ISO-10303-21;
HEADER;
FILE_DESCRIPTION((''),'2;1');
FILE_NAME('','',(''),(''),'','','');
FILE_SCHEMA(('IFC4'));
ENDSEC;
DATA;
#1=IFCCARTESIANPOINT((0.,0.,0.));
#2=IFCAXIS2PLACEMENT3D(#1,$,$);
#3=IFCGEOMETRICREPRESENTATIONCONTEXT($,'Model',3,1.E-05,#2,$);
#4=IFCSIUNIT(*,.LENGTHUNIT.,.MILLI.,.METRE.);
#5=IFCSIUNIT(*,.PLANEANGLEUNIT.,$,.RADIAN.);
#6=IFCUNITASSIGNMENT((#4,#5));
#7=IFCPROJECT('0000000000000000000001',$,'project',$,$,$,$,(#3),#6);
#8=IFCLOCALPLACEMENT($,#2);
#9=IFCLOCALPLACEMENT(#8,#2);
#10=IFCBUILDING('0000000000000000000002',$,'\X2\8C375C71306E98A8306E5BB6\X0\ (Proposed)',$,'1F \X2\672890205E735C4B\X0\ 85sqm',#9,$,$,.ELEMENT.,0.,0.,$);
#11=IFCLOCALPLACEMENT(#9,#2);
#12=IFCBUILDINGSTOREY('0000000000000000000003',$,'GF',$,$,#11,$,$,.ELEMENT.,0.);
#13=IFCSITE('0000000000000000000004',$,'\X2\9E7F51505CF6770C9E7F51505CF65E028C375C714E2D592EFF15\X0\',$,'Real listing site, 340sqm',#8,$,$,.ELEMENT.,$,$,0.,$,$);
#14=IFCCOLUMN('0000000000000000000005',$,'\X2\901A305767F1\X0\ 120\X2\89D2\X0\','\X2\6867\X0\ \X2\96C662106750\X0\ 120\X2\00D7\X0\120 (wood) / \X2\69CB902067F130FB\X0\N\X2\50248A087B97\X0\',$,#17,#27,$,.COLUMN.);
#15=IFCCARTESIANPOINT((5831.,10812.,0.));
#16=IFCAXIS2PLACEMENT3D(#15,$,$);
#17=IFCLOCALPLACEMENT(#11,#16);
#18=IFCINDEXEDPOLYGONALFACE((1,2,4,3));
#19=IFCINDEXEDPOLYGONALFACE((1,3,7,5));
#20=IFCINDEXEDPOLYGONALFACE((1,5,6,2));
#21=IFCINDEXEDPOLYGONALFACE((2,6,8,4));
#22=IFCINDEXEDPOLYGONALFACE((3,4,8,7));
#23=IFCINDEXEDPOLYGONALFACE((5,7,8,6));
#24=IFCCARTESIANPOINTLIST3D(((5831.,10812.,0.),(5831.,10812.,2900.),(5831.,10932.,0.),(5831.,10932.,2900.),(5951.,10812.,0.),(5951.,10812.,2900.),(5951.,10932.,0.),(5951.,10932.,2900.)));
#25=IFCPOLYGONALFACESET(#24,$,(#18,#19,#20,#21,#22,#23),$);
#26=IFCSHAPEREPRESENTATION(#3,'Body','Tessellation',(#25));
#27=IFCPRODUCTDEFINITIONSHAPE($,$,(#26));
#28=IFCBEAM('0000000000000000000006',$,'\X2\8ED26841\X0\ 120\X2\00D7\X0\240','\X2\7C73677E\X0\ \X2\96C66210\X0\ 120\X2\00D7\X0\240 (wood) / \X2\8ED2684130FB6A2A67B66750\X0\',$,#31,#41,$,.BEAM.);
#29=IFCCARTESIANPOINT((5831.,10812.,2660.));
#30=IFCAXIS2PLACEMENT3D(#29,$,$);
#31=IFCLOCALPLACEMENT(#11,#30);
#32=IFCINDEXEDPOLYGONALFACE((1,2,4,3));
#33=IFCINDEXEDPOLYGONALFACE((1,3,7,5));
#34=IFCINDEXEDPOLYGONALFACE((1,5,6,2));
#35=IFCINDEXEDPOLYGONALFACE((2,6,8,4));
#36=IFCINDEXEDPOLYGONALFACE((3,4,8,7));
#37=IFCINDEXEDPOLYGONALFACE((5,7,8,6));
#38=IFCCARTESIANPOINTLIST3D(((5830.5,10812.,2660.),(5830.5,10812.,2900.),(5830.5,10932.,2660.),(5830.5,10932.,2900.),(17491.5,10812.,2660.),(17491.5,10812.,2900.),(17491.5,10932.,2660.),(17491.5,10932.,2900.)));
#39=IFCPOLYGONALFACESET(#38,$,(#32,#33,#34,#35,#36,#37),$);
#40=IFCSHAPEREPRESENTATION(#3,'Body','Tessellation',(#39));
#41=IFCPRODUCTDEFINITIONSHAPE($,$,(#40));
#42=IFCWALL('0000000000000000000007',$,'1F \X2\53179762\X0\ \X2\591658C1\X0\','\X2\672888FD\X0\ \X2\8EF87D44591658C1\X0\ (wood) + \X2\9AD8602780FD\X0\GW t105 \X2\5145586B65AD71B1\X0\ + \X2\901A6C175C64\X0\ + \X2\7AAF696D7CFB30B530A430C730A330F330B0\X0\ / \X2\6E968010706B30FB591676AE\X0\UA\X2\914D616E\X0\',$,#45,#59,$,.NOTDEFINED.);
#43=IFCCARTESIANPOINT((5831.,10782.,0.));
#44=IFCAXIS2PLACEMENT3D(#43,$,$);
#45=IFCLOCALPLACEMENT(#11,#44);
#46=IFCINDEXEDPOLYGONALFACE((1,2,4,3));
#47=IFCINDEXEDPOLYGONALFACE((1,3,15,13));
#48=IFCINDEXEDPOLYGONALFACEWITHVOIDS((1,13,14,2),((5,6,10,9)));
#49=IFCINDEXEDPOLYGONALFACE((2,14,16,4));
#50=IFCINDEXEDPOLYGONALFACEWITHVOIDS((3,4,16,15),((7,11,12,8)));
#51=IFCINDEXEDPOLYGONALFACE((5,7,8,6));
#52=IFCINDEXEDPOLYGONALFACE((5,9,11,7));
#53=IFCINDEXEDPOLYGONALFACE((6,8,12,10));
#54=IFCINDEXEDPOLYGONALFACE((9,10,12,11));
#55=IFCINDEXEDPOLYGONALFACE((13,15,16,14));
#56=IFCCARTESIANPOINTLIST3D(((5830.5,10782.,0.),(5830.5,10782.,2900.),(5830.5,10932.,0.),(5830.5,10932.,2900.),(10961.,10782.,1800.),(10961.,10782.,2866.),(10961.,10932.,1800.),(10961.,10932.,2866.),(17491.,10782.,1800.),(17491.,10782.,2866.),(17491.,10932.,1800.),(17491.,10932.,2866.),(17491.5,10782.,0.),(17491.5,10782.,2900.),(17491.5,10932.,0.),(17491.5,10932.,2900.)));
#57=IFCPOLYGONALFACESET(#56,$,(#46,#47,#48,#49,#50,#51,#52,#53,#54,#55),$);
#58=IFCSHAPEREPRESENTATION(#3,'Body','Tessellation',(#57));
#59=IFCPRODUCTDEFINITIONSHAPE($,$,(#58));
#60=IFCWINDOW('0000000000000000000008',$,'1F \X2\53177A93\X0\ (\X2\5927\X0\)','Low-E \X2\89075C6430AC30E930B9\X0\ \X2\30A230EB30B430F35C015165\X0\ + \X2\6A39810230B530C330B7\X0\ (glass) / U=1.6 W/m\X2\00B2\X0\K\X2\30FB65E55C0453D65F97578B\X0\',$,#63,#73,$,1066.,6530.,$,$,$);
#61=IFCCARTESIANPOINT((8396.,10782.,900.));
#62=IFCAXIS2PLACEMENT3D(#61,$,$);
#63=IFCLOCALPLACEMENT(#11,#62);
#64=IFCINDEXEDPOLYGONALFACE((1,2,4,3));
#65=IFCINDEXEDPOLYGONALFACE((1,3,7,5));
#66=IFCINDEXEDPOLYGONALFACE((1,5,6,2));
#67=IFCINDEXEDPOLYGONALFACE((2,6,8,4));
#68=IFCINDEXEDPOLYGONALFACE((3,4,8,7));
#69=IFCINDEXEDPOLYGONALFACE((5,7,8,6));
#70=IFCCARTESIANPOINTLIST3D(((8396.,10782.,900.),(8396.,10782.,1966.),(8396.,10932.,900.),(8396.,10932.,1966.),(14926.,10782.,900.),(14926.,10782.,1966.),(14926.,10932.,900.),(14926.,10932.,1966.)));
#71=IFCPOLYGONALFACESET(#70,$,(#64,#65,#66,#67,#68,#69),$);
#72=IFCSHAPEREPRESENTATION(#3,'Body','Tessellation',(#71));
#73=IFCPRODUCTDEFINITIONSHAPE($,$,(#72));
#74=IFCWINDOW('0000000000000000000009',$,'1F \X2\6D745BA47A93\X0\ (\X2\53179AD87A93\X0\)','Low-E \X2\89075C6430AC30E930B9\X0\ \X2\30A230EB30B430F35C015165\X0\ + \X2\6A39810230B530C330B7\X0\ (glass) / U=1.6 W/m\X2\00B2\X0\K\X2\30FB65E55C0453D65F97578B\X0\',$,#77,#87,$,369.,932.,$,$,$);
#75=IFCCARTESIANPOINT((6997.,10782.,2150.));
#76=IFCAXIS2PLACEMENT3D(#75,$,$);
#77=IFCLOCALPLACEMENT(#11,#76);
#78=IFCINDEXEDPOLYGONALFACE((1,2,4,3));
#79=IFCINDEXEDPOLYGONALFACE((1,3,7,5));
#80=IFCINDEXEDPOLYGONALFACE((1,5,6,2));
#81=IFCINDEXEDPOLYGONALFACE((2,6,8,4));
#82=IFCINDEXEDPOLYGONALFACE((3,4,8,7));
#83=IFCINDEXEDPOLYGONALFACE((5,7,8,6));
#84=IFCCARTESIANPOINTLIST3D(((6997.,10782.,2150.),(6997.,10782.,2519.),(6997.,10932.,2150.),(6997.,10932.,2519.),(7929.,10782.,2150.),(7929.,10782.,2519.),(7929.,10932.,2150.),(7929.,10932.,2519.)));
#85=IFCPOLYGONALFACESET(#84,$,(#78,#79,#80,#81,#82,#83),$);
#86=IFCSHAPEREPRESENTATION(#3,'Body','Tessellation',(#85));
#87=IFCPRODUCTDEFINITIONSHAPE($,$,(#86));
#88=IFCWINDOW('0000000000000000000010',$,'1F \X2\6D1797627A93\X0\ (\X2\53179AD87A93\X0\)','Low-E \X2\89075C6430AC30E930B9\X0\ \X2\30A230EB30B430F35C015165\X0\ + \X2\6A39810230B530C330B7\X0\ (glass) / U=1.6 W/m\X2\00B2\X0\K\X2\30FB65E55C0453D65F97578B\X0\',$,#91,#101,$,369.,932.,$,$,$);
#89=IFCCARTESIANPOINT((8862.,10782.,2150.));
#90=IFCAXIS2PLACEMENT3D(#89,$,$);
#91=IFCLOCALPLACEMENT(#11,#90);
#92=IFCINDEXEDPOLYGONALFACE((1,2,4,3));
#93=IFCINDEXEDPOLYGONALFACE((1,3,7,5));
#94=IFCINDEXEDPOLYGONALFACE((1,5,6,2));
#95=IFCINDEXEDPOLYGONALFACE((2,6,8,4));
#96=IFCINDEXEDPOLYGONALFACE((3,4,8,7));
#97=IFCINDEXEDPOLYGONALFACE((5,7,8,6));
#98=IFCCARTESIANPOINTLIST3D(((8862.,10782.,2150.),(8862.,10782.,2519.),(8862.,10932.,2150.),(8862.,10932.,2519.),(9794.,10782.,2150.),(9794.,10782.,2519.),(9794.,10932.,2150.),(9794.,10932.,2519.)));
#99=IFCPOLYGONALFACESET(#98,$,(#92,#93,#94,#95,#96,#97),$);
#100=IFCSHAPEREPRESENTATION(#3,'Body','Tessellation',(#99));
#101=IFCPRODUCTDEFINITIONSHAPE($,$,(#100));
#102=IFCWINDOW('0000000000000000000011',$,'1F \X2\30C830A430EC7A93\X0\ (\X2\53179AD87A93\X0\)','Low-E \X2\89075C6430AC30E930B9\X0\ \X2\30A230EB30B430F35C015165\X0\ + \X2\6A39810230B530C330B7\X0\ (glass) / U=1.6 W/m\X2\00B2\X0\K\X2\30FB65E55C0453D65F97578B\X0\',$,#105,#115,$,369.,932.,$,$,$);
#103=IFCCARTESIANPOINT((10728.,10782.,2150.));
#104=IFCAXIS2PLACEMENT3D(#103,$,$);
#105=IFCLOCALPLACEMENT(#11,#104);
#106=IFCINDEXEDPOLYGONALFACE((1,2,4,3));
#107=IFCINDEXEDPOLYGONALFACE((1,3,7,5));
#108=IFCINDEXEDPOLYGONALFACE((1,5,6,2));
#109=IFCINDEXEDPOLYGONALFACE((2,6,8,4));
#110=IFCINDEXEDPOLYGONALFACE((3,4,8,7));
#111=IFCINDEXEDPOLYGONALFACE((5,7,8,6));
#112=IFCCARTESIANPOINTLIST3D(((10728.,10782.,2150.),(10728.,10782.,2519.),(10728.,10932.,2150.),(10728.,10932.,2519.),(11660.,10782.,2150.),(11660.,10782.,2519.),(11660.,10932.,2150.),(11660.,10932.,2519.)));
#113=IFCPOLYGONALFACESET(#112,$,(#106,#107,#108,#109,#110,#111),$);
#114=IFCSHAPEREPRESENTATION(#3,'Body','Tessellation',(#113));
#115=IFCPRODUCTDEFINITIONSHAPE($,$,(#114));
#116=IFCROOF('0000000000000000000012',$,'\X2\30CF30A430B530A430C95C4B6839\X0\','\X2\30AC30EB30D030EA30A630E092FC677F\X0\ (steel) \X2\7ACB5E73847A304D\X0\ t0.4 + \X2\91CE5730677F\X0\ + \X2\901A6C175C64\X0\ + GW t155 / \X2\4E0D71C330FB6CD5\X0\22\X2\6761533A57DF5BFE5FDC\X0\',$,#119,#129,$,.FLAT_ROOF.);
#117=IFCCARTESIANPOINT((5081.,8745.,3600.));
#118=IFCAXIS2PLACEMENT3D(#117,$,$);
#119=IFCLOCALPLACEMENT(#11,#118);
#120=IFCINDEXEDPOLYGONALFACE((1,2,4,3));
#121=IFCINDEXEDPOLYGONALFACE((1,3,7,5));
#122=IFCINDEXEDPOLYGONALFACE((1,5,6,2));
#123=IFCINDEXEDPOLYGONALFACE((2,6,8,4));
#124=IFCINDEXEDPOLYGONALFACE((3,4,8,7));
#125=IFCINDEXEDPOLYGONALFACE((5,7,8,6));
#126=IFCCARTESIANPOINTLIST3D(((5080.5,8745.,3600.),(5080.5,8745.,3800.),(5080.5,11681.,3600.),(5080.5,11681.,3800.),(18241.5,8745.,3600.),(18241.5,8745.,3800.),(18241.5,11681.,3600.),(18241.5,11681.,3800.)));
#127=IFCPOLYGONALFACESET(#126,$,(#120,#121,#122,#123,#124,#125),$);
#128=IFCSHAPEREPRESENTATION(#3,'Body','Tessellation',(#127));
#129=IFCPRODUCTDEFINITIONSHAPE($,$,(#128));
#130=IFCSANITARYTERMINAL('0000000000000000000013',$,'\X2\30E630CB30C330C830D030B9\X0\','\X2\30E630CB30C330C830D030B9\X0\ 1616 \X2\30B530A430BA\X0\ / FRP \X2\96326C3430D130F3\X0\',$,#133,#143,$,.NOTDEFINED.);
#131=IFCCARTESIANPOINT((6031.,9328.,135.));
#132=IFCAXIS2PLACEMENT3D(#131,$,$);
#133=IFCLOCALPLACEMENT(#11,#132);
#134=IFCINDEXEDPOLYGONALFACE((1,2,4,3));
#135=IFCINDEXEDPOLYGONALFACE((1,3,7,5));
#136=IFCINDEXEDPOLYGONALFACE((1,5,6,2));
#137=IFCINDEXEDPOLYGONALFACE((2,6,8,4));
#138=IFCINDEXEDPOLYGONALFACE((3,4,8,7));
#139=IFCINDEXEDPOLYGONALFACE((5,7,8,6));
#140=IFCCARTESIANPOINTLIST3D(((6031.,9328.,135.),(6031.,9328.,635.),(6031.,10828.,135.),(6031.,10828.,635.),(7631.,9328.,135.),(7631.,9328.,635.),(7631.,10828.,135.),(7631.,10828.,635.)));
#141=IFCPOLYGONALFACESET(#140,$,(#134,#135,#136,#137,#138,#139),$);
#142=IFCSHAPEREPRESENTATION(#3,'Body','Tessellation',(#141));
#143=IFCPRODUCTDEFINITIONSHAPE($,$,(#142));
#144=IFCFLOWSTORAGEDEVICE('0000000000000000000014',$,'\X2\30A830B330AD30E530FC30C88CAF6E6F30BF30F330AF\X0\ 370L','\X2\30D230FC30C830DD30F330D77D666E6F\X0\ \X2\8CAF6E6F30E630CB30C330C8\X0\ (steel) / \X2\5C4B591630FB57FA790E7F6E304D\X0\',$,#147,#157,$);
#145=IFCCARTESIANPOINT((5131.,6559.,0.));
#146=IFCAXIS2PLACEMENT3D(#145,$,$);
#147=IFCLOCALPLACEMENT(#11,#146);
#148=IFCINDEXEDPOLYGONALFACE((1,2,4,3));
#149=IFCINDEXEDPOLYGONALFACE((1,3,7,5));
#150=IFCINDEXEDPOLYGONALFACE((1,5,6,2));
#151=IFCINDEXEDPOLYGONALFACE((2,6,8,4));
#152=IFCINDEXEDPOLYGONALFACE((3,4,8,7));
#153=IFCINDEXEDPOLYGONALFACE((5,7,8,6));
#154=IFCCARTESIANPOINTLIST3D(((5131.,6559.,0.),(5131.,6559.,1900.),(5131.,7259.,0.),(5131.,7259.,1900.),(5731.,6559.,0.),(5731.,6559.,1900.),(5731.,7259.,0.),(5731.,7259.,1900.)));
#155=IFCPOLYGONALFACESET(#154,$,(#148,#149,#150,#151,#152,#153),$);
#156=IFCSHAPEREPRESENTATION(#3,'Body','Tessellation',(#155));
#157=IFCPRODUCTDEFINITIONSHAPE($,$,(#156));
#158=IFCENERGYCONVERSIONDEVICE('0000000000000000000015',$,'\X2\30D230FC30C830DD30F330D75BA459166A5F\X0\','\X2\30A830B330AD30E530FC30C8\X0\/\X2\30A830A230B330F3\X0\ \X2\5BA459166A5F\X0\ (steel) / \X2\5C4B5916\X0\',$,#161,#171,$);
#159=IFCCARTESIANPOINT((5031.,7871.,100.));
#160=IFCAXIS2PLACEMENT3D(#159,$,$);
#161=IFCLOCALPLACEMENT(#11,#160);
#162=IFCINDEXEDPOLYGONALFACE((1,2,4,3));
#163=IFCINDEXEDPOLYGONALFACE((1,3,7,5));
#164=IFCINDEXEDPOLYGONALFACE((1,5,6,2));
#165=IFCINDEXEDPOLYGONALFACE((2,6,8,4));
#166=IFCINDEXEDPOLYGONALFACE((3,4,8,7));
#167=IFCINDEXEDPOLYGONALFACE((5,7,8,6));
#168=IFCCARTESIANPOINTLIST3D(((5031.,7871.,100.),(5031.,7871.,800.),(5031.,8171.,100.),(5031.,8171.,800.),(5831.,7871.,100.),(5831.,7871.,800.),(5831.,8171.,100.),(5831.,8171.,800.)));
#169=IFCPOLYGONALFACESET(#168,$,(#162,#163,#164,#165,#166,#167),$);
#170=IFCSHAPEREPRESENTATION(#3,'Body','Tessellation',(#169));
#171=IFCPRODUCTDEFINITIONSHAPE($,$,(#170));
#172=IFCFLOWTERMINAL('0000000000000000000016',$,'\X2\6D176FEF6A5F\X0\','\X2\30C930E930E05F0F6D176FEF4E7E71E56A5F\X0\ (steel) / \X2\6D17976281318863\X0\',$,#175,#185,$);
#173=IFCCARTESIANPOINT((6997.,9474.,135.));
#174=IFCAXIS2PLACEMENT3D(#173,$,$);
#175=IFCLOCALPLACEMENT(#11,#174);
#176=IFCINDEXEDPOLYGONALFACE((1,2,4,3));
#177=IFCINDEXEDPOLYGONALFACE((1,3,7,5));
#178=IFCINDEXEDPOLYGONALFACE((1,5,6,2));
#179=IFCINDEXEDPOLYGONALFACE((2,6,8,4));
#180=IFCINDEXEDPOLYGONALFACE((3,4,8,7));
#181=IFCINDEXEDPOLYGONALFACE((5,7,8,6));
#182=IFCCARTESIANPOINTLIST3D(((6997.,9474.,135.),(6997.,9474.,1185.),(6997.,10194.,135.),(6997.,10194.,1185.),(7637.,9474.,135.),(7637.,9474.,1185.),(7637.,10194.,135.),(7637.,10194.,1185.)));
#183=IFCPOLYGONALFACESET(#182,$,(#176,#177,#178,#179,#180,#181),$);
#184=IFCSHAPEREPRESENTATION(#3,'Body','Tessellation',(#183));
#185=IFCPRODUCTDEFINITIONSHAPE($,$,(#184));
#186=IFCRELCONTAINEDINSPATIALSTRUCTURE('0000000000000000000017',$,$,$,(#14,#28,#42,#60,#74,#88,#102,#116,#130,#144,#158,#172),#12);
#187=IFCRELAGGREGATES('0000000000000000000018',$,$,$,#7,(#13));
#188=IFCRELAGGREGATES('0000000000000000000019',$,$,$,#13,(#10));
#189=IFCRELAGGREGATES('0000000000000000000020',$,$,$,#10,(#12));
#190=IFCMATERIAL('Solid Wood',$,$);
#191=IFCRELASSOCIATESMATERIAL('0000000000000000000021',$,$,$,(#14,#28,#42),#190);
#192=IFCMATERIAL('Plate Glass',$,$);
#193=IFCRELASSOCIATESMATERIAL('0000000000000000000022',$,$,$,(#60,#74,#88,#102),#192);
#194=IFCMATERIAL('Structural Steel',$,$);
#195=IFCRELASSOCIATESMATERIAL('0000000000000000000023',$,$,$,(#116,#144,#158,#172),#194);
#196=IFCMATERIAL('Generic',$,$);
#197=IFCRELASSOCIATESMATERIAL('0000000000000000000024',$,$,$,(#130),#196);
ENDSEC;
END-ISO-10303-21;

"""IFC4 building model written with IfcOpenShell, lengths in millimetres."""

from ifc_helpers import new_model, si_unit, frame, frame_2d, origin, place, context, project, spatial, rectangle, extrude, material, element, fill, save


model = new_model("IFC4")

# Units and contexts
model_context = context("Model", 3, precision=1e-05, world=origin())
ifc_project = project(units=[si_unit("LENGTHUNIT", "METRE", prefix="MILLI"), si_unit("PLANEANGLEUNIT", "RADIAN")], contexts=[model_context])

# Site, building, storey
site_placement = place(None, origin())
site = spatial("IfcSite", under=ifc_project, at=site_placement, Name="鹿児島県鹿児島市谷山中央５", ObjectType="Real listing site, 340sqm", CompositionType="ELEMENT", RefElevation=0.0)
building_placement = place(site_placement, origin())
building = spatial("IfcBuilding", under=site, at=building_placement, Name="谷山の風の家 (Proposed)", ObjectType="1F 木造平屋 85sqm", CompositionType="ELEMENT", ElevationOfRefHeight=0.0, ElevationOfTerrain=0.0)
storey_placement = place(building_placement, origin())
storey = spatial("IfcBuildingStorey", under=building, at=storey_placement, Name="GF", CompositionType="ELEMENT", Elevation=0.0)

# Column
ifc_material_1 = material(Name="Solid Wood")
column_1_placement = place(storey_placement, frame((5831.0, 10812.0, 0.0)))
element("IfcColumn", 1, at=column_1_placement, inside=storey, material=ifc_material_1, Name="通し柱 120角", Description="桧 集成材 120×120 (wood) / 構造柱・N値計算", PredefinedType="COLUMN", context=model_context, shape_type="SweptSolid", body=[
    extrude(rectangle(XDim=120.0, YDim=120.0, at=frame_2d((60.0, 60.0))), frame((5831.0, 10812.0, 0.0)), (0.0, 0.0, 1.0), 2900.0),
])

# Beam
beam_1_placement = place(storey_placement, frame((5831.0, 10812.0, 2660.0)))
element("IfcBeam", 2, at=beam_1_placement, inside=storey, material=ifc_material_1, Name="軒桁 120×240", Description="米松 集成 120×240 (wood) / 軒桁・横架材", PredefinedType="BEAM", context=model_context, shape_type="SweptSolid", body=[
    extrude(rectangle(XDim=11661.0, YDim=120.0, at=frame_2d((5830.0, 60.0))), frame((5831.0, 10812.0, 2660.0)), (0.0, 0.0, 1.0), 240.0),
])

# Wall, openings, windows
wall_1_placement = place(storey_placement, frame((5831.0, 10782.0, 0.0)))
wall_1 = element("IfcWall", 3, at=wall_1_placement, inside=storey, material=ifc_material_1, Name="1F 北面 外壁", Description="木製 軸組外壁 (wood) + 高性能GW t105 充填断熱 + 通気層 + 窯業系サイディング / 準耐火・外皮UA配慮", PredefinedType="NOTDEFINED", context=model_context, shape_type="SweptSolid", body=[
    extrude(rectangle(XDim=11661.0, YDim=150.0, at=frame_2d((5830.0, 75.0))), frame((5831.0, 10782.0, 0.0)), (0.0, 0.0, 1.0), 2900.0),
])
opening_1_placement = place(storey_placement, frame((8396.0, 10782.0, 900.0)))
opening_1 = element("IfcOpeningElement", 4, at=opening_1_placement, cuts=wall_1, PredefinedType="NOTDEFINED", context=model_context, shape_type="SweptSolid", body=[
    extrude(rectangle(XDim=6530.0, YDim=150.0, at=frame_2d((3265.0, 75.0))), frame((8396.0, 10782.0, 900.0)), (0.0, 0.0, 1.0), 1066.0),
])
opening_2_placement = place(storey_placement, frame((6997.0, 10782.0, 2150.0)))
opening_2 = element("IfcOpeningElement", 5, at=opening_2_placement, cuts=wall_1, PredefinedType="NOTDEFINED", context=model_context, shape_type="SweptSolid", body=[
    extrude(rectangle(XDim=932.0, YDim=150.0, at=frame_2d((466.0, 75.0))), frame((6997.0, 10782.0, 2150.0)), (0.0, 0.0, 1.0), 369.0),
])
opening_3_placement = place(storey_placement, frame((8862.0, 10782.0, 2150.0)))
opening_3 = element("IfcOpeningElement", 6, at=opening_3_placement, cuts=wall_1, PredefinedType="NOTDEFINED", context=model_context, shape_type="SweptSolid", body=[
    extrude(rectangle(XDim=932.0, YDim=150.0, at=frame_2d((466.0, 75.0))), frame((8862.0, 10782.0, 2150.0)), (0.0, 0.0, 1.0), 369.0),
])
opening_4_placement = place(storey_placement, frame((10728.0, 10782.0, 2150.0)))
opening_4 = element("IfcOpeningElement", 7, at=opening_4_placement, cuts=wall_1, PredefinedType="NOTDEFINED", context=model_context, shape_type="SweptSolid", body=[
    extrude(rectangle(XDim=932.0, YDim=150.0, at=frame_2d((466.0, 75.0))), frame((10728.0, 10782.0, 2150.0)), (0.0, 0.0, 1.0), 369.0),
])
ifc_material_2 = material(Name="Plate Glass")
window_1_placement = place(storey_placement, frame((8396.0, 10782.0, 900.0)))
window_1 = element("IfcWindow", 8, at=window_1_placement, inside=storey, material=ifc_material_2, Name="1F 北窓 (大)", Description="Low-E 複層ガラス アルゴン封入 + 樹脂サッシ (glass) / U=1.6 W/m²K・日射取得型", OverallHeight=1066.0, OverallWidth=6530.0, context=model_context, shape_type="SweptSolid", body=[
    extrude(rectangle(XDim=6530.0, YDim=150.0, at=frame_2d((3265.0, 75.0))), frame((8396.0, 10782.0, 900.0)), (0.0, 0.0, 1.0), 1066.0),
])
fill(opening_1, window_1)
window_2_placement = place(storey_placement, frame((6997.0, 10782.0, 2150.0)))
window_2 = element("IfcWindow", 9, at=window_2_placement, inside=storey, material=ifc_material_2, Name="1F 浴室窓 (北高窓)", Description="Low-E 複層ガラス アルゴン封入 + 樹脂サッシ (glass) / U=1.6 W/m²K・日射取得型", OverallHeight=369.0, OverallWidth=932.0, context=model_context, shape_type="SweptSolid", body=[
    extrude(rectangle(XDim=932.0, YDim=150.0, at=frame_2d((466.0, 75.0))), frame((6997.0, 10782.0, 2150.0)), (0.0, 0.0, 1.0), 369.0),
])
fill(opening_2, window_2)
window_3_placement = place(storey_placement, frame((8862.0, 10782.0, 2150.0)))
window_3 = element("IfcWindow", 10, at=window_3_placement, inside=storey, material=ifc_material_2, Name="1F 洗面窓 (北高窓)", Description="Low-E 複層ガラス アルゴン封入 + 樹脂サッシ (glass) / U=1.6 W/m²K・日射取得型", OverallHeight=369.0, OverallWidth=932.0, context=model_context, shape_type="SweptSolid", body=[
    extrude(rectangle(XDim=932.0, YDim=150.0, at=frame_2d((466.0, 75.0))), frame((8862.0, 10782.0, 2150.0)), (0.0, 0.0, 1.0), 369.0),
])
fill(opening_3, window_3)
window_4_placement = place(storey_placement, frame((10728.0, 10782.0, 2150.0)))
window_4 = element("IfcWindow", 11, at=window_4_placement, inside=storey, material=ifc_material_2, Name="1F トイレ窓 (北高窓)", Description="Low-E 複層ガラス アルゴン封入 + 樹脂サッシ (glass) / U=1.6 W/m²K・日射取得型", OverallHeight=369.0, OverallWidth=932.0, context=model_context, shape_type="SweptSolid", body=[
    extrude(rectangle(XDim=932.0, YDim=150.0, at=frame_2d((466.0, 75.0))), frame((10728.0, 10782.0, 2150.0)), (0.0, 0.0, 1.0), 369.0),
])
fill(opening_4, window_4)

# Roof
ifc_material_3 = material(Name="Structural Steel")
roof_placement = place(storey_placement, frame((5081.0, 8745.0, 3600.0)))
element("IfcRoof", 12, at=roof_placement, inside=storey, material=ifc_material_3, Name="ハイサイド屋根", Description="ガルバリウム鋼板 (steel) 立平葺き t0.4 + 野地板 + 通気層 + GW t155 / 不燃・法22条区域対応", PredefinedType="FLAT_ROOF", context=model_context, shape_type="SweptSolid", body=[
    extrude(rectangle(XDim=13161.0, YDim=2936.0, at=frame_2d((6580.0, 1468.0))), frame((5081.0, 8745.0, 3600.0)), (0.0, 0.0, 1.0), 200.0),
])

# Sanitary terminal
ifc_material_4 = material(Name="Generic")
sanitary_terminal_placement = place(storey_placement, frame((6031.0, 9328.0, 135.0)))
element("IfcSanitaryTerminal", 13, at=sanitary_terminal_placement, inside=storey, material=ifc_material_4, Name="ユニットバス", Description="ユニットバス 1616 サイズ / FRP 防水パン", PredefinedType="NOTDEFINED", context=model_context, shape_type="SweptSolid", body=[
    extrude(rectangle(XDim=1600.0, YDim=1500.0, at=frame_2d((800.0, 750.0))), frame((6031.0, 9328.0, 135.0)), (0.0, 0.0, 1.0), 500.0),
])

# Flow storage device
flow_storage_device_placement = place(storey_placement, frame((5131.0, 6559.0, 0.0)))
element("IfcFlowStorageDevice", 14, at=flow_storage_device_placement, inside=storey, material=ifc_material_3, Name="エコキュート貯湯タンク 370L", Description="ヒートポンプ給湯 貯湯ユニット (steel) / 屋外・基礎置き", context=model_context, shape_type="SweptSolid", body=[
    extrude(rectangle(XDim=600.0, YDim=700.0, at=frame_2d((300.0, 350.0))), frame((5131.0, 6559.0, 0.0)), (0.0, 0.0, 1.0), 1900.0),
])

# Energy conversion device
energy_conversion_device_placement = place(storey_placement, frame((5031.0, 7871.0, 100.0)))
element("IfcEnergyConversionDevice", 15, at=energy_conversion_device_placement, inside=storey, material=ifc_material_3, Name="ヒートポンプ室外機", Description="エコキュート/エアコン 室外機 (steel) / 屋外", context=model_context, shape_type="SweptSolid", body=[
    extrude(rectangle(XDim=800.0, YDim=300.0, at=frame_2d((400.0, 150.0))), frame((5031.0, 7871.0, 100.0)), (0.0, 0.0, 1.0), 700.0),
])

# Flow terminal
flow_terminal_placement = place(storey_placement, frame((6997.0, 9474.0, 135.0)))
element("IfcFlowTerminal", 16, at=flow_terminal_placement, inside=storey, material=ifc_material_3, Name="洗濯機", Description="ドラム式洗濯乾燥機 (steel) / 洗面脱衣", context=model_context, shape_type="SweptSolid", body=[
    extrude(rectangle(XDim=640.0, YDim=720.0, at=frame_2d((320.0, 360.0))), frame((6997.0, 9474.0, 135.0)), (0.0, 0.0, 1.0), 1050.0),
])

save(model, "model.ifc")
